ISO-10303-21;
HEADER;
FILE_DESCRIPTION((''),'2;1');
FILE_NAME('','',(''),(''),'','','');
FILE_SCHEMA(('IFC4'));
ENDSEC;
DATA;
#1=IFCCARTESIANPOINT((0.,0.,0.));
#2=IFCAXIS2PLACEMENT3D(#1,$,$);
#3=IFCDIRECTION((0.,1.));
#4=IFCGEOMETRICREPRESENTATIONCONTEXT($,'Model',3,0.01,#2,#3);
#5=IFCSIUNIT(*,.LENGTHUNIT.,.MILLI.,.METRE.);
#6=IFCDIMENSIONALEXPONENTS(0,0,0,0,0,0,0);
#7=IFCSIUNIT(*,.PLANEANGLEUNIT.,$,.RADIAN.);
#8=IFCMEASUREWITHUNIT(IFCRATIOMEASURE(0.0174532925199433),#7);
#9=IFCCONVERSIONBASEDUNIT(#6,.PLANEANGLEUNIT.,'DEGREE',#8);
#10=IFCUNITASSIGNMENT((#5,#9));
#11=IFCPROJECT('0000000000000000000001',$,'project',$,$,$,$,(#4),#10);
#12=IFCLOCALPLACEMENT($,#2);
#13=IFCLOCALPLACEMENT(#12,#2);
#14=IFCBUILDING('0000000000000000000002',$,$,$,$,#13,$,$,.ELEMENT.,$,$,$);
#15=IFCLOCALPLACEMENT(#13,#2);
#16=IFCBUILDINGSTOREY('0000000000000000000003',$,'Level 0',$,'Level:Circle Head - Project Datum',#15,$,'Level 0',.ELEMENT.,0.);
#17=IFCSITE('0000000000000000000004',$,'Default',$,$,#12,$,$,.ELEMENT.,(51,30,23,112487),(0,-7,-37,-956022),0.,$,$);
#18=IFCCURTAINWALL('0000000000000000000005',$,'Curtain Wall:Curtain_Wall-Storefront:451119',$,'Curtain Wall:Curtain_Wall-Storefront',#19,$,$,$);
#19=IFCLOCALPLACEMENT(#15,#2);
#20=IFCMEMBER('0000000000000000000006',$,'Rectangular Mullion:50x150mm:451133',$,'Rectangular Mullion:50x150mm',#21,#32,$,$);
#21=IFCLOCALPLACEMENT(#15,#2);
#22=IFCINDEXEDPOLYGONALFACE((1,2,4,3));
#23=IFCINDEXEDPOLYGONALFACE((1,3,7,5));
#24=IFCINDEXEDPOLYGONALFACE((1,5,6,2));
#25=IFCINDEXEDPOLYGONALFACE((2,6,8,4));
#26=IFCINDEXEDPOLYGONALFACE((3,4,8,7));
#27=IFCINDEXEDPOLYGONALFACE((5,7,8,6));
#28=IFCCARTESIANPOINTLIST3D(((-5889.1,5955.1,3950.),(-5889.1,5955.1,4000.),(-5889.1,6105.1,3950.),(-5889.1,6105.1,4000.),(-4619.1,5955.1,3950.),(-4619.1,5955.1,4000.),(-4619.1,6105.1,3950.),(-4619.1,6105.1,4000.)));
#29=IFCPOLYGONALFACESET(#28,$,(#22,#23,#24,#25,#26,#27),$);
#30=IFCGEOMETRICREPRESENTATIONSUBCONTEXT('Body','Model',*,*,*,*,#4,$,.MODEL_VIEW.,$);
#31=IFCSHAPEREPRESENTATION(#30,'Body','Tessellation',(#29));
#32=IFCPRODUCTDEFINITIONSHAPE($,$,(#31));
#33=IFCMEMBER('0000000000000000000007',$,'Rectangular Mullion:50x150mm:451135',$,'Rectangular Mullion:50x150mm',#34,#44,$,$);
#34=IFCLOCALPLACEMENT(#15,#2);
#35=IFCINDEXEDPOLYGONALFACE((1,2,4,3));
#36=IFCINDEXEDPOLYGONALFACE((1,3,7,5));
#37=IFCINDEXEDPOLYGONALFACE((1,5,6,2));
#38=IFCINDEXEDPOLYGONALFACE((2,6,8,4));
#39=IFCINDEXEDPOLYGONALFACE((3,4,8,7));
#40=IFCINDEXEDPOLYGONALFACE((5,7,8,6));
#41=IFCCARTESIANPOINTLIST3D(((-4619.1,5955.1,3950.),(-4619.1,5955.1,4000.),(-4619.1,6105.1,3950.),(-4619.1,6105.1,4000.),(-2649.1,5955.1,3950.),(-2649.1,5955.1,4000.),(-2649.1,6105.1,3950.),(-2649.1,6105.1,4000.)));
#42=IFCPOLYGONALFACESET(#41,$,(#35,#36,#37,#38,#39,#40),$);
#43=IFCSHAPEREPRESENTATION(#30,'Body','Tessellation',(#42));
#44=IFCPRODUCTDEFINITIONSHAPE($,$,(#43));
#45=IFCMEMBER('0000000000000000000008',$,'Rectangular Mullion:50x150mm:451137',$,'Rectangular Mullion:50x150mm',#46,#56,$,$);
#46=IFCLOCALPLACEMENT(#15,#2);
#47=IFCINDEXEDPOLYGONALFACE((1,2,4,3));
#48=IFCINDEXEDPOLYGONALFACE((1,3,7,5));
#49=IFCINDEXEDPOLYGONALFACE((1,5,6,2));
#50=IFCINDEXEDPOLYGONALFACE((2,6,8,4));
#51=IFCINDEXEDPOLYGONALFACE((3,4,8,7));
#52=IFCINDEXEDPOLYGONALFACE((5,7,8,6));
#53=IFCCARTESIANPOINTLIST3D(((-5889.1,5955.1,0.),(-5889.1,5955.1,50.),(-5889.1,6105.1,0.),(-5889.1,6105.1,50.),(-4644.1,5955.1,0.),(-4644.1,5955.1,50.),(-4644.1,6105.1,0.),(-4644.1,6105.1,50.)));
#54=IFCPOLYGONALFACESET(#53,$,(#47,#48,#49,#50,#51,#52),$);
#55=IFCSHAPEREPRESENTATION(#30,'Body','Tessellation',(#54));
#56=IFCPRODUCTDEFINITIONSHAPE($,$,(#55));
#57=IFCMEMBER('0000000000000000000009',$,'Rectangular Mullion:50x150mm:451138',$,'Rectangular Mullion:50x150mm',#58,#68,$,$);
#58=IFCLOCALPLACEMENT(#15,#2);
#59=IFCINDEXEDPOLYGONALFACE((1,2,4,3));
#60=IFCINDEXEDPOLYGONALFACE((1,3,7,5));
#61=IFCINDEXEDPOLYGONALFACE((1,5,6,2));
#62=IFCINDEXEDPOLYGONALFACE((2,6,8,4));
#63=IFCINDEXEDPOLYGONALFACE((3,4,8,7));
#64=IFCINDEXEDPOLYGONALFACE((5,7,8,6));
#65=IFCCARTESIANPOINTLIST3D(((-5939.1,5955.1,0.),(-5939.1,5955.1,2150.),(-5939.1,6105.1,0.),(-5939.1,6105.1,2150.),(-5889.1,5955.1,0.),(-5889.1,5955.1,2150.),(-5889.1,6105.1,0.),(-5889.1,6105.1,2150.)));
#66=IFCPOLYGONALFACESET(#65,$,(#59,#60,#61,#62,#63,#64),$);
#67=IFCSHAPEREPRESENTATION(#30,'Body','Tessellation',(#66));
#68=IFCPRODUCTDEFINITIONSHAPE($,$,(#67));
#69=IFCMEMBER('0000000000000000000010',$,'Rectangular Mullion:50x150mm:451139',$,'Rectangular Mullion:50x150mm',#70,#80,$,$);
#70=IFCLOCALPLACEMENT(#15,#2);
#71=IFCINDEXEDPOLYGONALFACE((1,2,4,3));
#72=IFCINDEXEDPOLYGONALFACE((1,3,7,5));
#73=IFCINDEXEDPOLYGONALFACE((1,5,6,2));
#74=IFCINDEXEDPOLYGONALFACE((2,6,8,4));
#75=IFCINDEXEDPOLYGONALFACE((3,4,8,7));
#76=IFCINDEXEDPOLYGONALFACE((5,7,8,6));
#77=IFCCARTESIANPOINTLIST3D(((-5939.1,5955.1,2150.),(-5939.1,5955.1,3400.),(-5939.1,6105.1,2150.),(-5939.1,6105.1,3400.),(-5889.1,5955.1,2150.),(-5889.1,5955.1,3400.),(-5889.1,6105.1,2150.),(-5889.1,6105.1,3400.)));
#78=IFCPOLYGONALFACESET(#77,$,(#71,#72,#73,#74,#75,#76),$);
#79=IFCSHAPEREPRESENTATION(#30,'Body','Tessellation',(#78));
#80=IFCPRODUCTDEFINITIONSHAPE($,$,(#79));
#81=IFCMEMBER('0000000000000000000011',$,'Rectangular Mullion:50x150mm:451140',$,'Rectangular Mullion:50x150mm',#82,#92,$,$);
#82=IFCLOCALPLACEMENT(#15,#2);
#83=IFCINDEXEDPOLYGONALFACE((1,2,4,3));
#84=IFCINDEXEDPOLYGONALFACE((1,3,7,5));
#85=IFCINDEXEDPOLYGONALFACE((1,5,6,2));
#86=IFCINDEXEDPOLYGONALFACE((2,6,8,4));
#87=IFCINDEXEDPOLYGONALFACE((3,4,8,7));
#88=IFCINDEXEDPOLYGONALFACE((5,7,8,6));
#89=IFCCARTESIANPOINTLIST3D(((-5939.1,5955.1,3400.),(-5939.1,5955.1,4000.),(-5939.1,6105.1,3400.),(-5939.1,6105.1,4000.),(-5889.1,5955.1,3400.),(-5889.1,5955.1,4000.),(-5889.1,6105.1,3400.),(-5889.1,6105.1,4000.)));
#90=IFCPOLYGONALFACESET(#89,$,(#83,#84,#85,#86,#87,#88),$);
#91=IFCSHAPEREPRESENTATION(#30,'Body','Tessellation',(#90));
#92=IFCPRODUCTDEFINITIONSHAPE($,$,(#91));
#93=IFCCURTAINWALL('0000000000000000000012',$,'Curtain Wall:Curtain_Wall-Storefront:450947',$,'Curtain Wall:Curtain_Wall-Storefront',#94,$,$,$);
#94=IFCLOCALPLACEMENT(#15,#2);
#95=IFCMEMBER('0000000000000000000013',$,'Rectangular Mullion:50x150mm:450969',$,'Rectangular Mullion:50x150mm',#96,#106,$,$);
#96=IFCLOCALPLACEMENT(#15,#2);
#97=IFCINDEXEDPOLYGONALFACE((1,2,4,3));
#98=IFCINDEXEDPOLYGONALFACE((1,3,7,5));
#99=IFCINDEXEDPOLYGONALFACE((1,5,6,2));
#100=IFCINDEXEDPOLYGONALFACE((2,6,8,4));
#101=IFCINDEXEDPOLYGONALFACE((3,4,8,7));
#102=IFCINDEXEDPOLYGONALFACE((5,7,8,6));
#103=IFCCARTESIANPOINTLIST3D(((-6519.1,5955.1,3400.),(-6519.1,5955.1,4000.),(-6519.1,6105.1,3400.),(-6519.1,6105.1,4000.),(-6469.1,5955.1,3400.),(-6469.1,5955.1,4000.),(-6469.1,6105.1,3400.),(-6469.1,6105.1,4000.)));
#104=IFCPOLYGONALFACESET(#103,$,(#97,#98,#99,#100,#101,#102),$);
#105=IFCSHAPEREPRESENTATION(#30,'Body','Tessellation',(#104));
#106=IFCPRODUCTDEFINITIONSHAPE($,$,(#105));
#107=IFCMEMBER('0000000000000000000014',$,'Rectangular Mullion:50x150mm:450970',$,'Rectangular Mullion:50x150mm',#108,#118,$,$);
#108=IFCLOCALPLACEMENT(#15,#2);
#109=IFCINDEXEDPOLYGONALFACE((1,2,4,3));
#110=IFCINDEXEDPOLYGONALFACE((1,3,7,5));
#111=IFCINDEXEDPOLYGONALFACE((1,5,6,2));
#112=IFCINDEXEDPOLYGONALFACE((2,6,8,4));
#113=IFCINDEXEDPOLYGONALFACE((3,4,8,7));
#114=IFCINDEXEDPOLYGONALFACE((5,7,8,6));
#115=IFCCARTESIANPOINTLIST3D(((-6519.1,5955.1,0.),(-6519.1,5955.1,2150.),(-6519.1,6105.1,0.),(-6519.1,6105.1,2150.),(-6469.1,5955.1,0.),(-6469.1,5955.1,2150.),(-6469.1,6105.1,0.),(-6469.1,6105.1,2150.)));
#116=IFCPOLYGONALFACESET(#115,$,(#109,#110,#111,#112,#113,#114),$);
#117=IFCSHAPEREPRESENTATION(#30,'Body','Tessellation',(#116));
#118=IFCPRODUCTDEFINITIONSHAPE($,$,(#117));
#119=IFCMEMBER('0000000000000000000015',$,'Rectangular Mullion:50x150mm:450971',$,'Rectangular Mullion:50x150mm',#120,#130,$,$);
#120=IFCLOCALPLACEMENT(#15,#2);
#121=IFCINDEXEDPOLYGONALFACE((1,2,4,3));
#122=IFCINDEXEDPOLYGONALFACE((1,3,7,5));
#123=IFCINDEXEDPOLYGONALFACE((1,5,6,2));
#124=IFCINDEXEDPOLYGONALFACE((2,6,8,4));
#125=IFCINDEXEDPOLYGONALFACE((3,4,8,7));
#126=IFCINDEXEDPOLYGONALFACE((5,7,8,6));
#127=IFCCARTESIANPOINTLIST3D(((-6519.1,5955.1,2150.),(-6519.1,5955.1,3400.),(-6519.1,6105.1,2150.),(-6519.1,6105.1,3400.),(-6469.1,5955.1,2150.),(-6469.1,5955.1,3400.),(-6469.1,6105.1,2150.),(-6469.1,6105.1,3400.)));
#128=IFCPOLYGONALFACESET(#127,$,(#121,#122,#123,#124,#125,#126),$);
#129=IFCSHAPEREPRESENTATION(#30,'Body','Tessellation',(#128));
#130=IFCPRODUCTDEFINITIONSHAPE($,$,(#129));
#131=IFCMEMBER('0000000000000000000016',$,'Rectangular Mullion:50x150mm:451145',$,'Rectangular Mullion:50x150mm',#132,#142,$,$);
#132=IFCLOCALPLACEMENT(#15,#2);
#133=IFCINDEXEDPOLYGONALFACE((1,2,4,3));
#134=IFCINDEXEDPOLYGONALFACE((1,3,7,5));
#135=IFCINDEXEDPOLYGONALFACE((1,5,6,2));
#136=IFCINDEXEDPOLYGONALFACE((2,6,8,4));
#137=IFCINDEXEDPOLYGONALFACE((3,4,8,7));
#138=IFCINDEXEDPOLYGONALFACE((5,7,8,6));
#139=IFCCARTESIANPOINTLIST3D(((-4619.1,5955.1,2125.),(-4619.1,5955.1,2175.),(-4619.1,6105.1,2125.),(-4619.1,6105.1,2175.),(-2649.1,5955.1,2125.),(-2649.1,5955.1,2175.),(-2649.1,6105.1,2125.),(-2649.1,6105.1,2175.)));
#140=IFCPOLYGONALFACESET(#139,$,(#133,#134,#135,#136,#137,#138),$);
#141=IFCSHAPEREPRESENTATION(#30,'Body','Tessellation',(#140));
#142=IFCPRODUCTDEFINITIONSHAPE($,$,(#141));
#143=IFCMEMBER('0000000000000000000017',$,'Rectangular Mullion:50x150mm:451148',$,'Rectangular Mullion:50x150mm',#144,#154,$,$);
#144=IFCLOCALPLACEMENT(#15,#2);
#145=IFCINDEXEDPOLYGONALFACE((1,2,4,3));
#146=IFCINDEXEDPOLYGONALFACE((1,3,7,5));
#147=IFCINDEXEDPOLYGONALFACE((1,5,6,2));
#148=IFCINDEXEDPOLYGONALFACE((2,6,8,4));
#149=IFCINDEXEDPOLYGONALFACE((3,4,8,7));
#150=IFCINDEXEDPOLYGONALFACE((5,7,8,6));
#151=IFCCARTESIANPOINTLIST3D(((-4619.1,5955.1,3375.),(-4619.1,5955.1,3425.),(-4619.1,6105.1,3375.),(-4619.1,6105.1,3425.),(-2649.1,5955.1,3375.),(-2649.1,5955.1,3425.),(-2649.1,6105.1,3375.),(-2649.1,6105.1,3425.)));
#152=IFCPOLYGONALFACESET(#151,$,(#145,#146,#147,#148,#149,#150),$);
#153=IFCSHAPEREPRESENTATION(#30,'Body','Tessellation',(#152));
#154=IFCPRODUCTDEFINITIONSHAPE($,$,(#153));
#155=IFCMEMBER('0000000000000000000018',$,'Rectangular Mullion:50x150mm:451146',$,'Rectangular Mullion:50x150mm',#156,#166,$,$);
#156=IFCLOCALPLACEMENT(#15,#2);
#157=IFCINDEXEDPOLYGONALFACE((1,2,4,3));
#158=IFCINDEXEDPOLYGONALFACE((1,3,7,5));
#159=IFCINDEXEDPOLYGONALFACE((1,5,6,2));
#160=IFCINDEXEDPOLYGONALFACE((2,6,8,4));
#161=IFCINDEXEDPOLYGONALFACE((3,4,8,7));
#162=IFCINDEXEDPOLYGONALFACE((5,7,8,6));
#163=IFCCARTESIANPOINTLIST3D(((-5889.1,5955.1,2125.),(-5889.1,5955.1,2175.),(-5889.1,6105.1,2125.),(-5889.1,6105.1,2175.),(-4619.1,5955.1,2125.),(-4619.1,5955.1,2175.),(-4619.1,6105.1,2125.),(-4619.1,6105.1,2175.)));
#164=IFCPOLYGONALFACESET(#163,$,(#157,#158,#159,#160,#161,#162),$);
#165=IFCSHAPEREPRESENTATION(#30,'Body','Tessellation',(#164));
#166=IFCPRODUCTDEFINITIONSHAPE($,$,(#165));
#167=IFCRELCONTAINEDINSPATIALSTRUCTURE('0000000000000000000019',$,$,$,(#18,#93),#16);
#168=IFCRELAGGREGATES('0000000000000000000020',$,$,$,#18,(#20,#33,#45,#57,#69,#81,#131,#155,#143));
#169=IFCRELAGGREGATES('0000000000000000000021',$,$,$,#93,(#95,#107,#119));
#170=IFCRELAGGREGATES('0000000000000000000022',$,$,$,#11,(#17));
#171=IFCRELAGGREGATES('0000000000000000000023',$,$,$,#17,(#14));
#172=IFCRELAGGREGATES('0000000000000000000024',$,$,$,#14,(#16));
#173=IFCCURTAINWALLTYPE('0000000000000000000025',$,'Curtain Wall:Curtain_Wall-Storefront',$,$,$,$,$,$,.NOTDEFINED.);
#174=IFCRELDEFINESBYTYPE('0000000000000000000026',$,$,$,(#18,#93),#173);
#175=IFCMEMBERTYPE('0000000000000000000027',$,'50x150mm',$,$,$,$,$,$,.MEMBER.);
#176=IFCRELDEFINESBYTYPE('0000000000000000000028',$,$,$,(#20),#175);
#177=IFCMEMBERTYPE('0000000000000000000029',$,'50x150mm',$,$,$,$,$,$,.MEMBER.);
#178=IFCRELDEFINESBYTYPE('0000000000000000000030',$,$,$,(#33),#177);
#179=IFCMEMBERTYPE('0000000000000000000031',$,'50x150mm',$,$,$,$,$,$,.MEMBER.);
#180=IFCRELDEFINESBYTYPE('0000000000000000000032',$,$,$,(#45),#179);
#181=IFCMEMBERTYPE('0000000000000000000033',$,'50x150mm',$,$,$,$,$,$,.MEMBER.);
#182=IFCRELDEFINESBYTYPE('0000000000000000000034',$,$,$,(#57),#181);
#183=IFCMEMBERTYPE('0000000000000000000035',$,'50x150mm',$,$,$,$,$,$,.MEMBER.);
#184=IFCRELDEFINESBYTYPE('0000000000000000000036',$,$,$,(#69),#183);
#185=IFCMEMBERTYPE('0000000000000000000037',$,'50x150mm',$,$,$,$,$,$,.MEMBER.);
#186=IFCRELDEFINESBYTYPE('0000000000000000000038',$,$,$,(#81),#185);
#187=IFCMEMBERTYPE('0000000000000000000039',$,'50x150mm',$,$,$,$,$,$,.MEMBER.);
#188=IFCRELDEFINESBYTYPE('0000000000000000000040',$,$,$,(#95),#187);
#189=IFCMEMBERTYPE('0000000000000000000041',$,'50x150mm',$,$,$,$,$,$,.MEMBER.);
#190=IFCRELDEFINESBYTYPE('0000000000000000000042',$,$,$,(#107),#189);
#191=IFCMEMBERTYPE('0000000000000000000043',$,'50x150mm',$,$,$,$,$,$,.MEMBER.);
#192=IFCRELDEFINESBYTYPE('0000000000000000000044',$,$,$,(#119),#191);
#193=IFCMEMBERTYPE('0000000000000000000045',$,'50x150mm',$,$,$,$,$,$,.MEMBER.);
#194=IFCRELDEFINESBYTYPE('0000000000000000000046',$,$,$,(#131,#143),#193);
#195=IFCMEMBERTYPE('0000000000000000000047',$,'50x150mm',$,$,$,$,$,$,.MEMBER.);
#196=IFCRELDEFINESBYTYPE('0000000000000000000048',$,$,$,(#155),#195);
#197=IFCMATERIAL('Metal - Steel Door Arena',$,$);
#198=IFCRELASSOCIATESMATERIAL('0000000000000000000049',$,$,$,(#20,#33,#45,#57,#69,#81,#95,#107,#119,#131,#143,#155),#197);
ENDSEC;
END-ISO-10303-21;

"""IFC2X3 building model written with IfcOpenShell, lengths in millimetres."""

from ifc_helpers import new_model, entity, si_unit, converted_unit, direction, frame, origin, origin_2d_with_axis, place, context, subcontext, project, spatial, rectangle, extrude, source, transform, mapped, material, type_object, type_shapes, element, aggregate, save


model = new_model("IFC2X3")

# Units and contexts
model_context = context("Model", 3, precision=0.01, world=origin(), true_north=direction((0.0, 1.0)))
body_context = subcontext(model_context, "Body", "Model", "MODEL_VIEW")
ifc_project = project(units=[si_unit("LENGTHUNIT", "METRE", prefix="MILLI"), converted_unit("PLANEANGLEUNIT", "DEGREE", entity("IfcRatioMeasure", 0.0174532925199433), si_unit("PLANEANGLEUNIT", "RADIAN"), dimensions=[0, 0, 0, 0, 0, 0, 0])], contexts=[model_context])

# Site, building, storey
site_placement = place(None, origin())
site = spatial("IfcSite", under=ifc_project, at=site_placement, Name="Default", CompositionType="ELEMENT", RefLatitude=(51, 30, 23, 112487), RefLongitude=(0, -7, -37, -956022), RefElevation=0.0)
building_placement = place(site_placement, origin())
building = spatial("IfcBuilding", under=site, at=building_placement, CompositionType="ELEMENT")
storey_placement = place(building_placement, origin())
storey = spatial("IfcBuildingStorey", under=building, at=storey_placement, Name="Level 0", ObjectType="Level:Circle Head - Project Datum", LongName="Level 0", CompositionType="ELEMENT", Elevation=0.0)

# Curtain walls, members
curtain_wall_type = type_object("IfcCurtainWallType", Name="Curtain Wall:Curtain_Wall-Storefront", PredefinedType="NOTDEFINED")
curtain_wall_1_placement = place(storey_placement, origin())
curtain_wall_1 = element("IfcCurtainWall", 1, at=curtain_wall_1_placement, inside=storey, type_object=curtain_wall_type, Name="Curtain Wall:Curtain_Wall-Storefront:451119", ObjectType="Curtain Wall:Curtain_Wall-Storefront")
ifc_material_1 = material(Name="Metal - Steel Door Arena")
member_type_1 = type_object("IfcMemberType", Name="50x150mm", PredefinedType="MEMBER")
shared_shape_1 = source(origin(), body_context, "Body", "SweptSolid", [
    extrude(rectangle(XDim=150.0, YDim=50.0, at=origin_2d_with_axis()), frame((-25.0, 0.0, -1270.0), z_axis=(0.0, 0.0, 1.0), x_axis=(0.0, -1.0, 0.0)), (0.0, 0.0, 1.0), 1270.0),
])
type_shapes(member_type_1, [shared_shape_1])
member_1_placement = place(storey_placement, frame((-5889.1, 6030.1, 4000.0), z_axis=(-1.0, 0.0, 0.0), x_axis=(0.0, 0.0, 1.0)))
member_1 = element("IfcMember", 2, at=member_1_placement, type_object=member_type_1, material=ifc_material_1, Name="Rectangular Mullion:50x150mm:451133", ObjectType="Rectangular Mullion:50x150mm", context=body_context, shape_type="MappedRepresentation", body=[
    mapped(shared_shape_1, transform((0.0, 0.0, 0.0), scale=1.0)),
])
member_type_2 = type_object("IfcMemberType", Name="50x150mm", PredefinedType="MEMBER")
shared_shape_2 = source(origin(), body_context, "Body", "SweptSolid", [
    extrude(rectangle(XDim=150.0, YDim=50.0, at=origin_2d_with_axis()), frame((-25.0, 0.0, -1970.0), z_axis=(0.0, 0.0, 1.0), x_axis=(0.0, -1.0, 0.0)), (0.0, 0.0, 1.0), 1970.0),
])
type_shapes(member_type_2, [shared_shape_2])
member_2_placement = place(storey_placement, frame((-4619.1, 6030.1, 4000.0), z_axis=(-1.0, 0.0, 0.0), x_axis=(0.0, 0.0, 1.0)))
member_2 = element("IfcMember", 3, at=member_2_placement, type_object=member_type_2, material=ifc_material_1, Name="Rectangular Mullion:50x150mm:451135", ObjectType="Rectangular Mullion:50x150mm", context=body_context, shape_type="MappedRepresentation", body=[
    mapped(shared_shape_2, transform((0.0, 0.0, 0.0), scale=1.0)),
])
member_type_3 = type_object("IfcMemberType", Name="50x150mm", PredefinedType="MEMBER")
shared_shape_3 = source(origin(), body_context, "Body", "SweptSolid", [
    extrude(rectangle(XDim=150.0, YDim=50.0, at=origin_2d_with_axis()), frame((-25.0, 0.0, -1245.0), z_axis=(0.0, 0.0, 1.0), x_axis=(0.0, -1.0, 0.0)), (0.0, 0.0, 1.0), 1245.0),
])
type_shapes(member_type_3, [shared_shape_3])
member_3_placement = place(storey_placement, frame((-4644.1, 6030.1, 0.0), z_axis=(1.0, 0.0, 0.0), x_axis=(0.0, 0.0, -1.0)))
member_3 = element("IfcMember", 4, at=member_3_placement, type_object=member_type_3, material=ifc_material_1, Name="Rectangular Mullion:50x150mm:451137", ObjectType="Rectangular Mullion:50x150mm", context=body_context, shape_type="MappedRepresentation", body=[
    mapped(shared_shape_3, transform((0.0, 0.0, 0.0), scale=1.0)),
])
member_type_4 = type_object("IfcMemberType", Name="50x150mm", PredefinedType="MEMBER")
shared_shape_4 = source(origin(), body_context, "Body", "SweptSolid", [
    extrude(rectangle(XDim=150.0, YDim=50.0, at=origin_2d_with_axis()), frame((-25.0, 0.0, -2150.0), z_axis=(0.0, 0.0, 1.0), x_axis=(0.0, -1.0, 0.0)), (0.0, 0.0, 1.0), 2150.0),
])
type_shapes(member_type_4, [shared_shape_4])
member_4_placement = place(storey_placement, frame((-5939.1, 6030.1, 0.0), z_axis=(0.0, 0.0, -1.0), x_axis=(-1.0, 0.0, 0.0)))
member_4 = element("IfcMember", 5, at=member_4_placement, type_object=member_type_4, material=ifc_material_1, Name="Rectangular Mullion:50x150mm:451138", ObjectType="Rectangular Mullion:50x150mm", context=body_context, shape_type="MappedRepresentation", body=[
    mapped(shared_shape_4, transform((0.0, 0.0, 0.0), scale=1.0)),
])
member_type_5 = type_object("IfcMemberType", Name="50x150mm", PredefinedType="MEMBER")
shared_shape_5 = source(origin(), body_context, "Body", "SweptSolid", [
    extrude(rectangle(XDim=150.0, YDim=50.0, at=origin_2d_with_axis()), frame((-25.0, 0.0, -1250.0), z_axis=(0.0, 0.0, 1.0), x_axis=(0.0, -1.0, 0.0)), (0.0, 0.0, 1.0), 1250.0),
])
type_shapes(member_type_5, [shared_shape_5])
member_5_placement = place(storey_placement, frame((-5939.1, 6030.1, 2150.0), z_axis=(0.0, 0.0, -1.0), x_axis=(-1.0, 0.0, 0.0)))
member_5 = element("IfcMember", 6, at=member_5_placement, type_object=member_type_5, material=ifc_material_1, Name="Rectangular Mullion:50x150mm:451139", ObjectType="Rectangular Mullion:50x150mm", context=body_context, shape_type="MappedRepresentation", body=[
    mapped(shared_shape_5, transform((0.0, 0.0, 0.0), scale=1.0)),
])
member_type_6 = type_object("IfcMemberType", Name="50x150mm", PredefinedType="MEMBER")
shared_shape_6 = source(origin(), body_context, "Body", "SweptSolid", [
    extrude(rectangle(XDim=150.0, YDim=50.0, at=origin_2d_with_axis()), frame((-25.0, 0.0, -600.0), z_axis=(0.0, 0.0, 1.0), x_axis=(0.0, -1.0, 0.0)), (0.0, 0.0, 1.0), 600.0),
])
type_shapes(member_type_6, [shared_shape_6])
member_6_placement = place(storey_placement, frame((-5939.1, 6030.1, 3400.0), z_axis=(0.0, 0.0, -1.0), x_axis=(-1.0, 0.0, 0.0)))
member_6 = element("IfcMember", 7, at=member_6_placement, type_object=member_type_6, material=ifc_material_1, Name="Rectangular Mullion:50x150mm:451140", ObjectType="Rectangular Mullion:50x150mm", context=body_context, shape_type="MappedRepresentation", body=[
    mapped(shared_shape_6, transform((0.0, 0.0, 0.0), scale=1.0)),
])
curtain_wall_2_placement = place(storey_placement, origin())
curtain_wall_2 = element("IfcCurtainWall", 8, at=curtain_wall_2_placement, inside=storey, type_object=curtain_wall_type, Name="Curtain Wall:Curtain_Wall-Storefront:450947", ObjectType="Curtain Wall:Curtain_Wall-Storefront")
member_type_7 = type_object("IfcMemberType", Name="50x150mm", PredefinedType="MEMBER")
shared_shape_7 = source(origin(), body_context, "Body", "SweptSolid", [
    extrude(rectangle(XDim=150.0, YDim=50.0, at=origin_2d_with_axis()), frame((-25.0, 0.0, -600.0), z_axis=(0.0, 0.0, 1.0), x_axis=(0.0, -1.0, 0.0)), (0.0, 0.0, 1.0), 600.0),
])
type_shapes(member_type_7, [shared_shape_7])
member_7_placement = place(storey_placement, frame((-6469.1, 6030.1, 4000.0)))
member_7 = element("IfcMember", 9, at=member_7_placement, type_object=member_type_7, material=ifc_material_1, Name="Rectangular Mullion:50x150mm:450969", ObjectType="Rectangular Mullion:50x150mm", context=body_context, shape_type="MappedRepresentation", body=[
    mapped(shared_shape_7, transform((0.0, 0.0, 0.0), scale=1.0)),
])
member_type_8 = type_object("IfcMemberType", Name="50x150mm", PredefinedType="MEMBER")
shared_shape_8 = source(origin(), body_context, "Body", "SweptSolid", [
    extrude(rectangle(XDim=150.0, YDim=50.0, at=origin_2d_with_axis()), frame((-25.0, 0.0, -2150.0), z_axis=(0.0, 0.0, 1.0), x_axis=(0.0, -1.0, 0.0)), (0.0, 0.0, 1.0), 2150.0),
])
type_shapes(member_type_8, [shared_shape_8])
member_8_placement = place(storey_placement, frame((-6469.1, 6030.1, 2150.0)))
member_8 = element("IfcMember", 10, at=member_8_placement, type_object=member_type_8, material=ifc_material_1, Name="Rectangular Mullion:50x150mm:450970", ObjectType="Rectangular Mullion:50x150mm", context=body_context, shape_type="MappedRepresentation", body=[
    mapped(shared_shape_8, transform((0.0, 0.0, 0.0), scale=1.0)),
])
member_type_9 = type_object("IfcMemberType", Name="50x150mm", PredefinedType="MEMBER")
shared_shape_9 = source(origin(), body_context, "Body", "SweptSolid", [
    extrude(rectangle(XDim=150.0, YDim=50.0, at=origin_2d_with_axis()), frame((-25.0, 0.0, -1250.0), z_axis=(0.0, 0.0, 1.0), x_axis=(0.0, -1.0, 0.0)), (0.0, 0.0, 1.0), 1250.0),
])
type_shapes(member_type_9, [shared_shape_9])
member_9_placement = place(storey_placement, frame((-6469.1, 6030.1, 3400.0)))
member_9 = element("IfcMember", 11, at=member_9_placement, type_object=member_type_9, material=ifc_material_1, Name="Rectangular Mullion:50x150mm:450971", ObjectType="Rectangular Mullion:50x150mm", context=body_context, shape_type="MappedRepresentation", body=[
    mapped(shared_shape_9, transform((0.0, 0.0, 0.0), scale=1.0)),
])

# Members
member_type_10 = type_object("IfcMemberType", Name="50x150mm", PredefinedType="MEMBER")
shared_shape_10 = source(origin(), body_context, "Body", "SweptSolid", [
    extrude(rectangle(XDim=150.0, YDim=50.0, at=origin_2d_with_axis()), frame((0.0, 0.0, -1970.0), z_axis=(0.0, 0.0, 1.0), x_axis=(0.0, -1.0, 0.0)), (0.0, 0.0, 1.0), 1970.0),
])
type_shapes(member_type_10, [shared_shape_10])
member_10_placement = place(storey_placement, frame((-4619.1, 6030.1, 2150.0), z_axis=(-1.0, 0.0, 0.0), x_axis=(0.0, 0.0, 1.0)))
member_10 = element("IfcMember", 12, at=member_10_placement, type_object=member_type_10, material=ifc_material_1, Name="Rectangular Mullion:50x150mm:451145", ObjectType="Rectangular Mullion:50x150mm", context=body_context, shape_type="MappedRepresentation", body=[
    mapped(shared_shape_10, transform((0.0, 0.0, 0.0), scale=1.0)),
])
member_11_placement = place(storey_placement, frame((-4619.1, 6030.1, 3400.0), z_axis=(-1.0, 0.0, 0.0), x_axis=(0.0, 0.0, 1.0)))
member_11 = element("IfcMember", 13, at=member_11_placement, type_object=member_type_10, material=ifc_material_1, Name="Rectangular Mullion:50x150mm:451148", ObjectType="Rectangular Mullion:50x150mm", context=body_context, shape_type="MappedRepresentation", body=[
    mapped(shared_shape_10, transform((0.0, 0.0, 0.0), scale=1.0)),
])
member_type_11 = type_object("IfcMemberType", Name="50x150mm", PredefinedType="MEMBER")
shared_shape_11 = source(origin(), body_context, "Body", "SweptSolid", [
    extrude(rectangle(XDim=150.0, YDim=50.0, at=origin_2d_with_axis()), frame((0.0, 0.0, -1270.0), z_axis=(0.0, 0.0, 1.0), x_axis=(0.0, -1.0, 0.0)), (0.0, 0.0, 1.0), 1270.0),
])
type_shapes(member_type_11, [shared_shape_11])
member_12_placement = place(storey_placement, frame((-5889.1, 6030.1, 2150.0), z_axis=(-1.0, 0.0, 0.0), x_axis=(0.0, 0.0, 1.0)))
member_12 = element("IfcMember", 14, at=member_12_placement, type_object=member_type_11, material=ifc_material_1, Name="Rectangular Mullion:50x150mm:451146", ObjectType="Rectangular Mullion:50x150mm", context=body_context, shape_type="MappedRepresentation", body=[
    mapped(shared_shape_11, transform((0.0, 0.0, 0.0), scale=1.0)),
])

aggregate(curtain_wall_1, [member_1, member_2, member_3, member_4, member_5, member_6, member_10, member_12, member_11])
aggregate(curtain_wall_2, [member_7, member_8, member_9])

save(model, "model.ifc")
